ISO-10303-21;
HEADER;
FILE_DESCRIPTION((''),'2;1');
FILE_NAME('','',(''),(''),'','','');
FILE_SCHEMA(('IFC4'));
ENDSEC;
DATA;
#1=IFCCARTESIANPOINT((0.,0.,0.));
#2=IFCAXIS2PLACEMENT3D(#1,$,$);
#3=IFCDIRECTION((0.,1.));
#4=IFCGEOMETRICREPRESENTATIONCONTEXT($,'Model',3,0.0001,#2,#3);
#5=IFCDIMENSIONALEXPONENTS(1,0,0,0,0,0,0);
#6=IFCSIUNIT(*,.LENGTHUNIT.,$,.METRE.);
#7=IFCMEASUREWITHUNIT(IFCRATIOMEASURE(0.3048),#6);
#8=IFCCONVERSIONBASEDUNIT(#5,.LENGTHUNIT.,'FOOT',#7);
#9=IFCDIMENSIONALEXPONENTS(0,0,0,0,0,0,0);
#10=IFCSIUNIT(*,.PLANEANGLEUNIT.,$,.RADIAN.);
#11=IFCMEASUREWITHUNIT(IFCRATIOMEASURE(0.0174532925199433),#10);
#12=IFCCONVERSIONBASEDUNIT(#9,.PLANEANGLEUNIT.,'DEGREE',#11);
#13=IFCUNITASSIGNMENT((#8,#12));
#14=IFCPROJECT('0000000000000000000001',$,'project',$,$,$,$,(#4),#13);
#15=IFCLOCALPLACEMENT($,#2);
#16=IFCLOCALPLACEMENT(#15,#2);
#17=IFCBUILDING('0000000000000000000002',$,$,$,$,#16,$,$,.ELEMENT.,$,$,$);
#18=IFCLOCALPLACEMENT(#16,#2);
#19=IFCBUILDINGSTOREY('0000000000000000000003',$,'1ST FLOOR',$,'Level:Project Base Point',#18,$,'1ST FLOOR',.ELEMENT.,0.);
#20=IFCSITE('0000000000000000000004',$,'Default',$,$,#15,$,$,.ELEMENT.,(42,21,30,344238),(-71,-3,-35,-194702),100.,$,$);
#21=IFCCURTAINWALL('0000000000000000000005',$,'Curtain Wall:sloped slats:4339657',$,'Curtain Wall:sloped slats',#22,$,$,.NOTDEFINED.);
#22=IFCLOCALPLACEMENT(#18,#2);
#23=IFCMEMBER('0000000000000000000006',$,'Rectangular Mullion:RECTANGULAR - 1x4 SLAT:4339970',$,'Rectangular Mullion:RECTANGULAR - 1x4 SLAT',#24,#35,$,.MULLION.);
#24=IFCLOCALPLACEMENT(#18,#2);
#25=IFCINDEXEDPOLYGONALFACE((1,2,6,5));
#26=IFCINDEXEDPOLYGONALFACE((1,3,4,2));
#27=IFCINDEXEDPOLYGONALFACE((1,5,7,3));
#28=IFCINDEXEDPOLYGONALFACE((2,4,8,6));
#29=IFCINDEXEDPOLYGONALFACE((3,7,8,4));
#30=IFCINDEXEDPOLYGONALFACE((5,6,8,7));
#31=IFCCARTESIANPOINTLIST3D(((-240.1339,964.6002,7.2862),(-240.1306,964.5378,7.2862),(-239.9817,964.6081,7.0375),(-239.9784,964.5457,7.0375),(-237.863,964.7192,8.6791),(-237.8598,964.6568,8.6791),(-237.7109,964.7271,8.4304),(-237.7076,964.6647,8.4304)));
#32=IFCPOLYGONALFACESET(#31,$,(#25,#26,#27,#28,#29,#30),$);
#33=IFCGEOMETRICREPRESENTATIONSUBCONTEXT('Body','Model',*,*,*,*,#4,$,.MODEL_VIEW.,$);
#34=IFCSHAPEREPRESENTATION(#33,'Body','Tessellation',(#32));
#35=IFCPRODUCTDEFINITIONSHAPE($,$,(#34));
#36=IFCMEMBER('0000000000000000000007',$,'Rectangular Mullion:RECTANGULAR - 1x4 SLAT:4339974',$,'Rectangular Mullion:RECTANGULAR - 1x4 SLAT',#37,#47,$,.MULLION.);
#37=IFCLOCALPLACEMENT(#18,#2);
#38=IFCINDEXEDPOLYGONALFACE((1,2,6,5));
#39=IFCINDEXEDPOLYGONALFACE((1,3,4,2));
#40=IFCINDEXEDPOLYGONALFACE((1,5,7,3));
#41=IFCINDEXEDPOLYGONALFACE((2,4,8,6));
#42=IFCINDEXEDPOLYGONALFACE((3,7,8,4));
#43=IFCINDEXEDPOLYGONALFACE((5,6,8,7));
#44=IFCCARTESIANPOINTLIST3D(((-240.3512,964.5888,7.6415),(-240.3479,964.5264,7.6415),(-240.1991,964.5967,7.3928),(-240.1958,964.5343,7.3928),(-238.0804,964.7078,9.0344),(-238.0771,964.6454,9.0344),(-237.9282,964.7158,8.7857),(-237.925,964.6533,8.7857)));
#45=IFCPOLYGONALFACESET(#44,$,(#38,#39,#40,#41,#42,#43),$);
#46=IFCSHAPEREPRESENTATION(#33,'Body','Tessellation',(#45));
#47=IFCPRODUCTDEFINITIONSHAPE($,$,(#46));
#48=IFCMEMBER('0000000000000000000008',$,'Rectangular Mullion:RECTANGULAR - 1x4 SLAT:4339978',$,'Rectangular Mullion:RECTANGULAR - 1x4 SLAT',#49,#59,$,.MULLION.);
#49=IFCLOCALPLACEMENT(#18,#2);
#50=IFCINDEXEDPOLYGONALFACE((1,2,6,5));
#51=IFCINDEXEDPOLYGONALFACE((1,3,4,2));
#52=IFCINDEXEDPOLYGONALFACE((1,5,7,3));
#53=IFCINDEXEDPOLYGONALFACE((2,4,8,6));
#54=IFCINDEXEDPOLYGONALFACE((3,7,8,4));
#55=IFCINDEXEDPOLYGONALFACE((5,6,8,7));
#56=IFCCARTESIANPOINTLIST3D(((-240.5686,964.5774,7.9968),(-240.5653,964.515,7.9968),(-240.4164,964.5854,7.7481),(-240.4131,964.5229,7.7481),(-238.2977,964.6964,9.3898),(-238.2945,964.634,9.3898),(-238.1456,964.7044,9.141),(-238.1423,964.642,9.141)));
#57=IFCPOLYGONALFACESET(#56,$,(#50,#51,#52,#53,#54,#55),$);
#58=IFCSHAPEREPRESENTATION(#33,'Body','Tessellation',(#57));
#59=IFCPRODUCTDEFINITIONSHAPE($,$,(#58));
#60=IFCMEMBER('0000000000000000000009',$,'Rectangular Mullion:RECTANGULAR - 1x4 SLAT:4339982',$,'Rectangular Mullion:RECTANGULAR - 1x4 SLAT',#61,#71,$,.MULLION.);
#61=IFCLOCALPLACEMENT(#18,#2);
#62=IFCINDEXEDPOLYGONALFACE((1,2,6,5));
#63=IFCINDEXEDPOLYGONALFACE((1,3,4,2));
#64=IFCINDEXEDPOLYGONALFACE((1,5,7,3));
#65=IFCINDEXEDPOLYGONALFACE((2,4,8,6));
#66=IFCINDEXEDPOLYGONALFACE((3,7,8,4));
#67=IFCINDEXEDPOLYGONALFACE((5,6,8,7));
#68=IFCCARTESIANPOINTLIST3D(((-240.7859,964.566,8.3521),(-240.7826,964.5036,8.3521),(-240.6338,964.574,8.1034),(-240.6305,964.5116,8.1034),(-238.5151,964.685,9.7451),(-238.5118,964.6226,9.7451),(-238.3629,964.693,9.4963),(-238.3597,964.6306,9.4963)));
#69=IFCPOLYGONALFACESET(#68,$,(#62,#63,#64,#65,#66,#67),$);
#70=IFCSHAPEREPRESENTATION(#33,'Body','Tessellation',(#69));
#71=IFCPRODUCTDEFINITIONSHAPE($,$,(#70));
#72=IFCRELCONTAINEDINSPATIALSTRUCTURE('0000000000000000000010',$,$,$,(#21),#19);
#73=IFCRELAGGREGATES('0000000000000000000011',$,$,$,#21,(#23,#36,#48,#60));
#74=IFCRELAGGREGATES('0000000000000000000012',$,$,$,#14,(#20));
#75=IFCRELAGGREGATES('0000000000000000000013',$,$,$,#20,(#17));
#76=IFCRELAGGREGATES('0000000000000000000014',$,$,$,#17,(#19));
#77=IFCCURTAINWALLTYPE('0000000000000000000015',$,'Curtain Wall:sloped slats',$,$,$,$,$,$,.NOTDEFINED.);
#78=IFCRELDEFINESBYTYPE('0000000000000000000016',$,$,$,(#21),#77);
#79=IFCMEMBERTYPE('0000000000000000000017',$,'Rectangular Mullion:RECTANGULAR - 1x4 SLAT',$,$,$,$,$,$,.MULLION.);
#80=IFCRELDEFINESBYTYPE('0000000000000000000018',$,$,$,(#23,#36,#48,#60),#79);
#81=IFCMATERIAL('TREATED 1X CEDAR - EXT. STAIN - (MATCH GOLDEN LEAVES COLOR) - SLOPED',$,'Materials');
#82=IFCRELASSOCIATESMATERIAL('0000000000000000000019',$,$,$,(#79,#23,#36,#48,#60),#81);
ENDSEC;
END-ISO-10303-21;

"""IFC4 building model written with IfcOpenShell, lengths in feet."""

from ifc_helpers import new_model, entity, si_unit, converted_unit, direction, frame, frame_2d, origin, place, context, subcontext, project, spatial, rectangle, extrude, source, transform, mapped, material, material_profile, profile_set, profile_usage, type_object, type_shapes, element, aggregate, save


model = new_model("IFC4")

# Units and contexts
model_context = context("Model", 3, precision=0.0001, world=origin(), true_north=direction((0.0, 1.0)))
body_context = subcontext(model_context, "Body", "Model", "MODEL_VIEW")
ifc_project = project(units=[converted_unit("LENGTHUNIT", "FOOT", entity("IfcRatioMeasure", 0.3048), si_unit("LENGTHUNIT", "METRE"), dimensions=[1, 0, 0, 0, 0, 0, 0]), converted_unit("PLANEANGLEUNIT", "DEGREE", entity("IfcRatioMeasure", 0.0174532925199433), si_unit("PLANEANGLEUNIT", "RADIAN"), dimensions=[0, 0, 0, 0, 0, 0, 0])], contexts=[model_context])

# Site, building, storey
site_placement = place(None, origin())
site = spatial("IfcSite", under=ifc_project, at=site_placement, Name="Default", CompositionType="ELEMENT", RefLatitude=(42, 21, 30, 344238), RefLongitude=(-71, -3, -35, -194702), RefElevation=100.0)
building_placement = place(site_placement, origin())
building = spatial("IfcBuilding", under=site, at=building_placement, CompositionType="ELEMENT")
storey_placement = place(building_placement, origin())
storey = spatial("IfcBuildingStorey", under=building, at=storey_placement, Name="1ST FLOOR", ObjectType="Level:Project Base Point", LongName="1ST FLOOR", CompositionType="ELEMENT", Elevation=0.0)

# Curtain wall, members
curtain_wall_type_1 = type_object("IfcCurtainWallType", Name="Curtain Wall:sloped slats", PredefinedType="NOTDEFINED")
ifc_material_1 = material(Name="TREATED 1X CEDAR - EXT. STAIN - (MATCH GOLDEN LEAVES COLOR) - SLOPED", Category="Materials")
ifc_material_profile_1 = material_profile(ifc_material_1, rectangle(XDim=0.0625, YDim=0.2917, at=frame_2d((0.0, 0.0), x_axis=(1.0, 0.0))), Name="RECTANGULAR - 1x4 SLAT")
ifc_profile_set_1 = profile_set([ifc_material_profile_1], Name="RECTANGULAR - 1x4 SLAT")
member_type_1 = type_object("IfcMemberType", Name="Rectangular Mullion:RECTANGULAR - 1x4 SLAT", PredefinedType="MULLION", material=ifc_profile_set_1)
shared_shape_1 = source(origin(), body_context, "Body", "SweptSolid", [
    extrude(rectangle(XDim=0.0625, YDim=0.2917, at=frame_2d((0.0, 0.0), x_axis=(1.0, 0.0))), frame((0.0, 0.0, -2.6667), z_axis=(0.0, 0.0, 1.0), x_axis=(0.0, -1.0, 0.0)), (0.0, 0.0, 1.0), 2.6667),
])
type_shapes(member_type_1, [shared_shape_1])
curtain_wall_1_placement = place(storey_placement, origin())
curtain_wall_1 = element("IfcCurtainWall", 1, at=curtain_wall_1_placement, inside=storey, type_object=curtain_wall_type_1, Name="Curtain Wall:sloped slats:4339657", ObjectType="Curtain Wall:sloped slats", PredefinedType="NOTDEFINED")
ifc_profile_usage_1 = profile_usage(ifc_profile_set_1)
member_1_placement = place(storey_placement, frame((-240.0562, 964.5729, 7.1618), z_axis=(-0.851559, -0.044628, -0.522356), x_axis=(-0.52164, -0.027338, 0.852727)))
member_1 = element("IfcMember", 2, at=member_1_placement, type_object=member_type_1, material=ifc_profile_usage_1, Name="Rectangular Mullion:RECTANGULAR - 1x4 SLAT:4339970", ObjectType="Rectangular Mullion:RECTANGULAR - 1x4 SLAT", PredefinedType="MULLION", context=body_context, shape_type="MappedRepresentation", body=[
    mapped(shared_shape_1, transform((0.0, 0.0, 0.0), scale=1.0)),
])
ifc_profile_usage_2 = profile_usage(ifc_profile_set_1)
member_2_placement = place(storey_placement, frame((-240.2735, 964.5616, 7.5171), z_axis=(-0.851559, -0.044628, -0.522356), x_axis=(-0.52164, -0.027338, 0.852727)))
member_2 = element("IfcMember", 3, at=member_2_placement, type_object=member_type_1, material=ifc_profile_usage_2, Name="Rectangular Mullion:RECTANGULAR - 1x4 SLAT:4339974", ObjectType="Rectangular Mullion:RECTANGULAR - 1x4 SLAT", PredefinedType="MULLION", context=body_context, shape_type="MappedRepresentation", body=[
    mapped(shared_shape_1, transform((0.0, 0.0, 0.0), scale=1.0)),
])
ifc_profile_usage_3 = profile_usage(ifc_profile_set_1)
member_3_placement = place(storey_placement, frame((-240.4909, 964.5502, 7.8724), z_axis=(-0.851559, -0.044628, -0.522356), x_axis=(-0.52164, -0.027338, 0.852727)))
member_3 = element("IfcMember", 4, at=member_3_placement, type_object=member_type_1, material=ifc_profile_usage_3, Name="Rectangular Mullion:RECTANGULAR - 1x4 SLAT:4339978", ObjectType="Rectangular Mullion:RECTANGULAR - 1x4 SLAT", PredefinedType="MULLION", context=body_context, shape_type="MappedRepresentation", body=[
    mapped(shared_shape_1, transform((0.0, 0.0, 0.0), scale=1.0)),
])
ifc_profile_usage_4 = profile_usage(ifc_profile_set_1)
member_4_placement = place(storey_placement, frame((-240.7082, 964.5388, 8.2277), z_axis=(-0.851559, -0.044628, -0.522356), x_axis=(-0.52164, -0.027338, 0.852727)))
member_4 = element("IfcMember", 5, at=member_4_placement, type_object=member_type_1, material=ifc_profile_usage_4, Name="Rectangular Mullion:RECTANGULAR - 1x4 SLAT:4339982", ObjectType="Rectangular Mullion:RECTANGULAR - 1x4 SLAT", PredefinedType="MULLION", context=body_context, shape_type="MappedRepresentation", body=[
    mapped(shared_shape_1, transform((0.0, 0.0, 0.0), scale=1.0)),
])
aggregate(curtain_wall_1, [member_1, member_2, member_3, member_4])

save(model, "model.ifc")
